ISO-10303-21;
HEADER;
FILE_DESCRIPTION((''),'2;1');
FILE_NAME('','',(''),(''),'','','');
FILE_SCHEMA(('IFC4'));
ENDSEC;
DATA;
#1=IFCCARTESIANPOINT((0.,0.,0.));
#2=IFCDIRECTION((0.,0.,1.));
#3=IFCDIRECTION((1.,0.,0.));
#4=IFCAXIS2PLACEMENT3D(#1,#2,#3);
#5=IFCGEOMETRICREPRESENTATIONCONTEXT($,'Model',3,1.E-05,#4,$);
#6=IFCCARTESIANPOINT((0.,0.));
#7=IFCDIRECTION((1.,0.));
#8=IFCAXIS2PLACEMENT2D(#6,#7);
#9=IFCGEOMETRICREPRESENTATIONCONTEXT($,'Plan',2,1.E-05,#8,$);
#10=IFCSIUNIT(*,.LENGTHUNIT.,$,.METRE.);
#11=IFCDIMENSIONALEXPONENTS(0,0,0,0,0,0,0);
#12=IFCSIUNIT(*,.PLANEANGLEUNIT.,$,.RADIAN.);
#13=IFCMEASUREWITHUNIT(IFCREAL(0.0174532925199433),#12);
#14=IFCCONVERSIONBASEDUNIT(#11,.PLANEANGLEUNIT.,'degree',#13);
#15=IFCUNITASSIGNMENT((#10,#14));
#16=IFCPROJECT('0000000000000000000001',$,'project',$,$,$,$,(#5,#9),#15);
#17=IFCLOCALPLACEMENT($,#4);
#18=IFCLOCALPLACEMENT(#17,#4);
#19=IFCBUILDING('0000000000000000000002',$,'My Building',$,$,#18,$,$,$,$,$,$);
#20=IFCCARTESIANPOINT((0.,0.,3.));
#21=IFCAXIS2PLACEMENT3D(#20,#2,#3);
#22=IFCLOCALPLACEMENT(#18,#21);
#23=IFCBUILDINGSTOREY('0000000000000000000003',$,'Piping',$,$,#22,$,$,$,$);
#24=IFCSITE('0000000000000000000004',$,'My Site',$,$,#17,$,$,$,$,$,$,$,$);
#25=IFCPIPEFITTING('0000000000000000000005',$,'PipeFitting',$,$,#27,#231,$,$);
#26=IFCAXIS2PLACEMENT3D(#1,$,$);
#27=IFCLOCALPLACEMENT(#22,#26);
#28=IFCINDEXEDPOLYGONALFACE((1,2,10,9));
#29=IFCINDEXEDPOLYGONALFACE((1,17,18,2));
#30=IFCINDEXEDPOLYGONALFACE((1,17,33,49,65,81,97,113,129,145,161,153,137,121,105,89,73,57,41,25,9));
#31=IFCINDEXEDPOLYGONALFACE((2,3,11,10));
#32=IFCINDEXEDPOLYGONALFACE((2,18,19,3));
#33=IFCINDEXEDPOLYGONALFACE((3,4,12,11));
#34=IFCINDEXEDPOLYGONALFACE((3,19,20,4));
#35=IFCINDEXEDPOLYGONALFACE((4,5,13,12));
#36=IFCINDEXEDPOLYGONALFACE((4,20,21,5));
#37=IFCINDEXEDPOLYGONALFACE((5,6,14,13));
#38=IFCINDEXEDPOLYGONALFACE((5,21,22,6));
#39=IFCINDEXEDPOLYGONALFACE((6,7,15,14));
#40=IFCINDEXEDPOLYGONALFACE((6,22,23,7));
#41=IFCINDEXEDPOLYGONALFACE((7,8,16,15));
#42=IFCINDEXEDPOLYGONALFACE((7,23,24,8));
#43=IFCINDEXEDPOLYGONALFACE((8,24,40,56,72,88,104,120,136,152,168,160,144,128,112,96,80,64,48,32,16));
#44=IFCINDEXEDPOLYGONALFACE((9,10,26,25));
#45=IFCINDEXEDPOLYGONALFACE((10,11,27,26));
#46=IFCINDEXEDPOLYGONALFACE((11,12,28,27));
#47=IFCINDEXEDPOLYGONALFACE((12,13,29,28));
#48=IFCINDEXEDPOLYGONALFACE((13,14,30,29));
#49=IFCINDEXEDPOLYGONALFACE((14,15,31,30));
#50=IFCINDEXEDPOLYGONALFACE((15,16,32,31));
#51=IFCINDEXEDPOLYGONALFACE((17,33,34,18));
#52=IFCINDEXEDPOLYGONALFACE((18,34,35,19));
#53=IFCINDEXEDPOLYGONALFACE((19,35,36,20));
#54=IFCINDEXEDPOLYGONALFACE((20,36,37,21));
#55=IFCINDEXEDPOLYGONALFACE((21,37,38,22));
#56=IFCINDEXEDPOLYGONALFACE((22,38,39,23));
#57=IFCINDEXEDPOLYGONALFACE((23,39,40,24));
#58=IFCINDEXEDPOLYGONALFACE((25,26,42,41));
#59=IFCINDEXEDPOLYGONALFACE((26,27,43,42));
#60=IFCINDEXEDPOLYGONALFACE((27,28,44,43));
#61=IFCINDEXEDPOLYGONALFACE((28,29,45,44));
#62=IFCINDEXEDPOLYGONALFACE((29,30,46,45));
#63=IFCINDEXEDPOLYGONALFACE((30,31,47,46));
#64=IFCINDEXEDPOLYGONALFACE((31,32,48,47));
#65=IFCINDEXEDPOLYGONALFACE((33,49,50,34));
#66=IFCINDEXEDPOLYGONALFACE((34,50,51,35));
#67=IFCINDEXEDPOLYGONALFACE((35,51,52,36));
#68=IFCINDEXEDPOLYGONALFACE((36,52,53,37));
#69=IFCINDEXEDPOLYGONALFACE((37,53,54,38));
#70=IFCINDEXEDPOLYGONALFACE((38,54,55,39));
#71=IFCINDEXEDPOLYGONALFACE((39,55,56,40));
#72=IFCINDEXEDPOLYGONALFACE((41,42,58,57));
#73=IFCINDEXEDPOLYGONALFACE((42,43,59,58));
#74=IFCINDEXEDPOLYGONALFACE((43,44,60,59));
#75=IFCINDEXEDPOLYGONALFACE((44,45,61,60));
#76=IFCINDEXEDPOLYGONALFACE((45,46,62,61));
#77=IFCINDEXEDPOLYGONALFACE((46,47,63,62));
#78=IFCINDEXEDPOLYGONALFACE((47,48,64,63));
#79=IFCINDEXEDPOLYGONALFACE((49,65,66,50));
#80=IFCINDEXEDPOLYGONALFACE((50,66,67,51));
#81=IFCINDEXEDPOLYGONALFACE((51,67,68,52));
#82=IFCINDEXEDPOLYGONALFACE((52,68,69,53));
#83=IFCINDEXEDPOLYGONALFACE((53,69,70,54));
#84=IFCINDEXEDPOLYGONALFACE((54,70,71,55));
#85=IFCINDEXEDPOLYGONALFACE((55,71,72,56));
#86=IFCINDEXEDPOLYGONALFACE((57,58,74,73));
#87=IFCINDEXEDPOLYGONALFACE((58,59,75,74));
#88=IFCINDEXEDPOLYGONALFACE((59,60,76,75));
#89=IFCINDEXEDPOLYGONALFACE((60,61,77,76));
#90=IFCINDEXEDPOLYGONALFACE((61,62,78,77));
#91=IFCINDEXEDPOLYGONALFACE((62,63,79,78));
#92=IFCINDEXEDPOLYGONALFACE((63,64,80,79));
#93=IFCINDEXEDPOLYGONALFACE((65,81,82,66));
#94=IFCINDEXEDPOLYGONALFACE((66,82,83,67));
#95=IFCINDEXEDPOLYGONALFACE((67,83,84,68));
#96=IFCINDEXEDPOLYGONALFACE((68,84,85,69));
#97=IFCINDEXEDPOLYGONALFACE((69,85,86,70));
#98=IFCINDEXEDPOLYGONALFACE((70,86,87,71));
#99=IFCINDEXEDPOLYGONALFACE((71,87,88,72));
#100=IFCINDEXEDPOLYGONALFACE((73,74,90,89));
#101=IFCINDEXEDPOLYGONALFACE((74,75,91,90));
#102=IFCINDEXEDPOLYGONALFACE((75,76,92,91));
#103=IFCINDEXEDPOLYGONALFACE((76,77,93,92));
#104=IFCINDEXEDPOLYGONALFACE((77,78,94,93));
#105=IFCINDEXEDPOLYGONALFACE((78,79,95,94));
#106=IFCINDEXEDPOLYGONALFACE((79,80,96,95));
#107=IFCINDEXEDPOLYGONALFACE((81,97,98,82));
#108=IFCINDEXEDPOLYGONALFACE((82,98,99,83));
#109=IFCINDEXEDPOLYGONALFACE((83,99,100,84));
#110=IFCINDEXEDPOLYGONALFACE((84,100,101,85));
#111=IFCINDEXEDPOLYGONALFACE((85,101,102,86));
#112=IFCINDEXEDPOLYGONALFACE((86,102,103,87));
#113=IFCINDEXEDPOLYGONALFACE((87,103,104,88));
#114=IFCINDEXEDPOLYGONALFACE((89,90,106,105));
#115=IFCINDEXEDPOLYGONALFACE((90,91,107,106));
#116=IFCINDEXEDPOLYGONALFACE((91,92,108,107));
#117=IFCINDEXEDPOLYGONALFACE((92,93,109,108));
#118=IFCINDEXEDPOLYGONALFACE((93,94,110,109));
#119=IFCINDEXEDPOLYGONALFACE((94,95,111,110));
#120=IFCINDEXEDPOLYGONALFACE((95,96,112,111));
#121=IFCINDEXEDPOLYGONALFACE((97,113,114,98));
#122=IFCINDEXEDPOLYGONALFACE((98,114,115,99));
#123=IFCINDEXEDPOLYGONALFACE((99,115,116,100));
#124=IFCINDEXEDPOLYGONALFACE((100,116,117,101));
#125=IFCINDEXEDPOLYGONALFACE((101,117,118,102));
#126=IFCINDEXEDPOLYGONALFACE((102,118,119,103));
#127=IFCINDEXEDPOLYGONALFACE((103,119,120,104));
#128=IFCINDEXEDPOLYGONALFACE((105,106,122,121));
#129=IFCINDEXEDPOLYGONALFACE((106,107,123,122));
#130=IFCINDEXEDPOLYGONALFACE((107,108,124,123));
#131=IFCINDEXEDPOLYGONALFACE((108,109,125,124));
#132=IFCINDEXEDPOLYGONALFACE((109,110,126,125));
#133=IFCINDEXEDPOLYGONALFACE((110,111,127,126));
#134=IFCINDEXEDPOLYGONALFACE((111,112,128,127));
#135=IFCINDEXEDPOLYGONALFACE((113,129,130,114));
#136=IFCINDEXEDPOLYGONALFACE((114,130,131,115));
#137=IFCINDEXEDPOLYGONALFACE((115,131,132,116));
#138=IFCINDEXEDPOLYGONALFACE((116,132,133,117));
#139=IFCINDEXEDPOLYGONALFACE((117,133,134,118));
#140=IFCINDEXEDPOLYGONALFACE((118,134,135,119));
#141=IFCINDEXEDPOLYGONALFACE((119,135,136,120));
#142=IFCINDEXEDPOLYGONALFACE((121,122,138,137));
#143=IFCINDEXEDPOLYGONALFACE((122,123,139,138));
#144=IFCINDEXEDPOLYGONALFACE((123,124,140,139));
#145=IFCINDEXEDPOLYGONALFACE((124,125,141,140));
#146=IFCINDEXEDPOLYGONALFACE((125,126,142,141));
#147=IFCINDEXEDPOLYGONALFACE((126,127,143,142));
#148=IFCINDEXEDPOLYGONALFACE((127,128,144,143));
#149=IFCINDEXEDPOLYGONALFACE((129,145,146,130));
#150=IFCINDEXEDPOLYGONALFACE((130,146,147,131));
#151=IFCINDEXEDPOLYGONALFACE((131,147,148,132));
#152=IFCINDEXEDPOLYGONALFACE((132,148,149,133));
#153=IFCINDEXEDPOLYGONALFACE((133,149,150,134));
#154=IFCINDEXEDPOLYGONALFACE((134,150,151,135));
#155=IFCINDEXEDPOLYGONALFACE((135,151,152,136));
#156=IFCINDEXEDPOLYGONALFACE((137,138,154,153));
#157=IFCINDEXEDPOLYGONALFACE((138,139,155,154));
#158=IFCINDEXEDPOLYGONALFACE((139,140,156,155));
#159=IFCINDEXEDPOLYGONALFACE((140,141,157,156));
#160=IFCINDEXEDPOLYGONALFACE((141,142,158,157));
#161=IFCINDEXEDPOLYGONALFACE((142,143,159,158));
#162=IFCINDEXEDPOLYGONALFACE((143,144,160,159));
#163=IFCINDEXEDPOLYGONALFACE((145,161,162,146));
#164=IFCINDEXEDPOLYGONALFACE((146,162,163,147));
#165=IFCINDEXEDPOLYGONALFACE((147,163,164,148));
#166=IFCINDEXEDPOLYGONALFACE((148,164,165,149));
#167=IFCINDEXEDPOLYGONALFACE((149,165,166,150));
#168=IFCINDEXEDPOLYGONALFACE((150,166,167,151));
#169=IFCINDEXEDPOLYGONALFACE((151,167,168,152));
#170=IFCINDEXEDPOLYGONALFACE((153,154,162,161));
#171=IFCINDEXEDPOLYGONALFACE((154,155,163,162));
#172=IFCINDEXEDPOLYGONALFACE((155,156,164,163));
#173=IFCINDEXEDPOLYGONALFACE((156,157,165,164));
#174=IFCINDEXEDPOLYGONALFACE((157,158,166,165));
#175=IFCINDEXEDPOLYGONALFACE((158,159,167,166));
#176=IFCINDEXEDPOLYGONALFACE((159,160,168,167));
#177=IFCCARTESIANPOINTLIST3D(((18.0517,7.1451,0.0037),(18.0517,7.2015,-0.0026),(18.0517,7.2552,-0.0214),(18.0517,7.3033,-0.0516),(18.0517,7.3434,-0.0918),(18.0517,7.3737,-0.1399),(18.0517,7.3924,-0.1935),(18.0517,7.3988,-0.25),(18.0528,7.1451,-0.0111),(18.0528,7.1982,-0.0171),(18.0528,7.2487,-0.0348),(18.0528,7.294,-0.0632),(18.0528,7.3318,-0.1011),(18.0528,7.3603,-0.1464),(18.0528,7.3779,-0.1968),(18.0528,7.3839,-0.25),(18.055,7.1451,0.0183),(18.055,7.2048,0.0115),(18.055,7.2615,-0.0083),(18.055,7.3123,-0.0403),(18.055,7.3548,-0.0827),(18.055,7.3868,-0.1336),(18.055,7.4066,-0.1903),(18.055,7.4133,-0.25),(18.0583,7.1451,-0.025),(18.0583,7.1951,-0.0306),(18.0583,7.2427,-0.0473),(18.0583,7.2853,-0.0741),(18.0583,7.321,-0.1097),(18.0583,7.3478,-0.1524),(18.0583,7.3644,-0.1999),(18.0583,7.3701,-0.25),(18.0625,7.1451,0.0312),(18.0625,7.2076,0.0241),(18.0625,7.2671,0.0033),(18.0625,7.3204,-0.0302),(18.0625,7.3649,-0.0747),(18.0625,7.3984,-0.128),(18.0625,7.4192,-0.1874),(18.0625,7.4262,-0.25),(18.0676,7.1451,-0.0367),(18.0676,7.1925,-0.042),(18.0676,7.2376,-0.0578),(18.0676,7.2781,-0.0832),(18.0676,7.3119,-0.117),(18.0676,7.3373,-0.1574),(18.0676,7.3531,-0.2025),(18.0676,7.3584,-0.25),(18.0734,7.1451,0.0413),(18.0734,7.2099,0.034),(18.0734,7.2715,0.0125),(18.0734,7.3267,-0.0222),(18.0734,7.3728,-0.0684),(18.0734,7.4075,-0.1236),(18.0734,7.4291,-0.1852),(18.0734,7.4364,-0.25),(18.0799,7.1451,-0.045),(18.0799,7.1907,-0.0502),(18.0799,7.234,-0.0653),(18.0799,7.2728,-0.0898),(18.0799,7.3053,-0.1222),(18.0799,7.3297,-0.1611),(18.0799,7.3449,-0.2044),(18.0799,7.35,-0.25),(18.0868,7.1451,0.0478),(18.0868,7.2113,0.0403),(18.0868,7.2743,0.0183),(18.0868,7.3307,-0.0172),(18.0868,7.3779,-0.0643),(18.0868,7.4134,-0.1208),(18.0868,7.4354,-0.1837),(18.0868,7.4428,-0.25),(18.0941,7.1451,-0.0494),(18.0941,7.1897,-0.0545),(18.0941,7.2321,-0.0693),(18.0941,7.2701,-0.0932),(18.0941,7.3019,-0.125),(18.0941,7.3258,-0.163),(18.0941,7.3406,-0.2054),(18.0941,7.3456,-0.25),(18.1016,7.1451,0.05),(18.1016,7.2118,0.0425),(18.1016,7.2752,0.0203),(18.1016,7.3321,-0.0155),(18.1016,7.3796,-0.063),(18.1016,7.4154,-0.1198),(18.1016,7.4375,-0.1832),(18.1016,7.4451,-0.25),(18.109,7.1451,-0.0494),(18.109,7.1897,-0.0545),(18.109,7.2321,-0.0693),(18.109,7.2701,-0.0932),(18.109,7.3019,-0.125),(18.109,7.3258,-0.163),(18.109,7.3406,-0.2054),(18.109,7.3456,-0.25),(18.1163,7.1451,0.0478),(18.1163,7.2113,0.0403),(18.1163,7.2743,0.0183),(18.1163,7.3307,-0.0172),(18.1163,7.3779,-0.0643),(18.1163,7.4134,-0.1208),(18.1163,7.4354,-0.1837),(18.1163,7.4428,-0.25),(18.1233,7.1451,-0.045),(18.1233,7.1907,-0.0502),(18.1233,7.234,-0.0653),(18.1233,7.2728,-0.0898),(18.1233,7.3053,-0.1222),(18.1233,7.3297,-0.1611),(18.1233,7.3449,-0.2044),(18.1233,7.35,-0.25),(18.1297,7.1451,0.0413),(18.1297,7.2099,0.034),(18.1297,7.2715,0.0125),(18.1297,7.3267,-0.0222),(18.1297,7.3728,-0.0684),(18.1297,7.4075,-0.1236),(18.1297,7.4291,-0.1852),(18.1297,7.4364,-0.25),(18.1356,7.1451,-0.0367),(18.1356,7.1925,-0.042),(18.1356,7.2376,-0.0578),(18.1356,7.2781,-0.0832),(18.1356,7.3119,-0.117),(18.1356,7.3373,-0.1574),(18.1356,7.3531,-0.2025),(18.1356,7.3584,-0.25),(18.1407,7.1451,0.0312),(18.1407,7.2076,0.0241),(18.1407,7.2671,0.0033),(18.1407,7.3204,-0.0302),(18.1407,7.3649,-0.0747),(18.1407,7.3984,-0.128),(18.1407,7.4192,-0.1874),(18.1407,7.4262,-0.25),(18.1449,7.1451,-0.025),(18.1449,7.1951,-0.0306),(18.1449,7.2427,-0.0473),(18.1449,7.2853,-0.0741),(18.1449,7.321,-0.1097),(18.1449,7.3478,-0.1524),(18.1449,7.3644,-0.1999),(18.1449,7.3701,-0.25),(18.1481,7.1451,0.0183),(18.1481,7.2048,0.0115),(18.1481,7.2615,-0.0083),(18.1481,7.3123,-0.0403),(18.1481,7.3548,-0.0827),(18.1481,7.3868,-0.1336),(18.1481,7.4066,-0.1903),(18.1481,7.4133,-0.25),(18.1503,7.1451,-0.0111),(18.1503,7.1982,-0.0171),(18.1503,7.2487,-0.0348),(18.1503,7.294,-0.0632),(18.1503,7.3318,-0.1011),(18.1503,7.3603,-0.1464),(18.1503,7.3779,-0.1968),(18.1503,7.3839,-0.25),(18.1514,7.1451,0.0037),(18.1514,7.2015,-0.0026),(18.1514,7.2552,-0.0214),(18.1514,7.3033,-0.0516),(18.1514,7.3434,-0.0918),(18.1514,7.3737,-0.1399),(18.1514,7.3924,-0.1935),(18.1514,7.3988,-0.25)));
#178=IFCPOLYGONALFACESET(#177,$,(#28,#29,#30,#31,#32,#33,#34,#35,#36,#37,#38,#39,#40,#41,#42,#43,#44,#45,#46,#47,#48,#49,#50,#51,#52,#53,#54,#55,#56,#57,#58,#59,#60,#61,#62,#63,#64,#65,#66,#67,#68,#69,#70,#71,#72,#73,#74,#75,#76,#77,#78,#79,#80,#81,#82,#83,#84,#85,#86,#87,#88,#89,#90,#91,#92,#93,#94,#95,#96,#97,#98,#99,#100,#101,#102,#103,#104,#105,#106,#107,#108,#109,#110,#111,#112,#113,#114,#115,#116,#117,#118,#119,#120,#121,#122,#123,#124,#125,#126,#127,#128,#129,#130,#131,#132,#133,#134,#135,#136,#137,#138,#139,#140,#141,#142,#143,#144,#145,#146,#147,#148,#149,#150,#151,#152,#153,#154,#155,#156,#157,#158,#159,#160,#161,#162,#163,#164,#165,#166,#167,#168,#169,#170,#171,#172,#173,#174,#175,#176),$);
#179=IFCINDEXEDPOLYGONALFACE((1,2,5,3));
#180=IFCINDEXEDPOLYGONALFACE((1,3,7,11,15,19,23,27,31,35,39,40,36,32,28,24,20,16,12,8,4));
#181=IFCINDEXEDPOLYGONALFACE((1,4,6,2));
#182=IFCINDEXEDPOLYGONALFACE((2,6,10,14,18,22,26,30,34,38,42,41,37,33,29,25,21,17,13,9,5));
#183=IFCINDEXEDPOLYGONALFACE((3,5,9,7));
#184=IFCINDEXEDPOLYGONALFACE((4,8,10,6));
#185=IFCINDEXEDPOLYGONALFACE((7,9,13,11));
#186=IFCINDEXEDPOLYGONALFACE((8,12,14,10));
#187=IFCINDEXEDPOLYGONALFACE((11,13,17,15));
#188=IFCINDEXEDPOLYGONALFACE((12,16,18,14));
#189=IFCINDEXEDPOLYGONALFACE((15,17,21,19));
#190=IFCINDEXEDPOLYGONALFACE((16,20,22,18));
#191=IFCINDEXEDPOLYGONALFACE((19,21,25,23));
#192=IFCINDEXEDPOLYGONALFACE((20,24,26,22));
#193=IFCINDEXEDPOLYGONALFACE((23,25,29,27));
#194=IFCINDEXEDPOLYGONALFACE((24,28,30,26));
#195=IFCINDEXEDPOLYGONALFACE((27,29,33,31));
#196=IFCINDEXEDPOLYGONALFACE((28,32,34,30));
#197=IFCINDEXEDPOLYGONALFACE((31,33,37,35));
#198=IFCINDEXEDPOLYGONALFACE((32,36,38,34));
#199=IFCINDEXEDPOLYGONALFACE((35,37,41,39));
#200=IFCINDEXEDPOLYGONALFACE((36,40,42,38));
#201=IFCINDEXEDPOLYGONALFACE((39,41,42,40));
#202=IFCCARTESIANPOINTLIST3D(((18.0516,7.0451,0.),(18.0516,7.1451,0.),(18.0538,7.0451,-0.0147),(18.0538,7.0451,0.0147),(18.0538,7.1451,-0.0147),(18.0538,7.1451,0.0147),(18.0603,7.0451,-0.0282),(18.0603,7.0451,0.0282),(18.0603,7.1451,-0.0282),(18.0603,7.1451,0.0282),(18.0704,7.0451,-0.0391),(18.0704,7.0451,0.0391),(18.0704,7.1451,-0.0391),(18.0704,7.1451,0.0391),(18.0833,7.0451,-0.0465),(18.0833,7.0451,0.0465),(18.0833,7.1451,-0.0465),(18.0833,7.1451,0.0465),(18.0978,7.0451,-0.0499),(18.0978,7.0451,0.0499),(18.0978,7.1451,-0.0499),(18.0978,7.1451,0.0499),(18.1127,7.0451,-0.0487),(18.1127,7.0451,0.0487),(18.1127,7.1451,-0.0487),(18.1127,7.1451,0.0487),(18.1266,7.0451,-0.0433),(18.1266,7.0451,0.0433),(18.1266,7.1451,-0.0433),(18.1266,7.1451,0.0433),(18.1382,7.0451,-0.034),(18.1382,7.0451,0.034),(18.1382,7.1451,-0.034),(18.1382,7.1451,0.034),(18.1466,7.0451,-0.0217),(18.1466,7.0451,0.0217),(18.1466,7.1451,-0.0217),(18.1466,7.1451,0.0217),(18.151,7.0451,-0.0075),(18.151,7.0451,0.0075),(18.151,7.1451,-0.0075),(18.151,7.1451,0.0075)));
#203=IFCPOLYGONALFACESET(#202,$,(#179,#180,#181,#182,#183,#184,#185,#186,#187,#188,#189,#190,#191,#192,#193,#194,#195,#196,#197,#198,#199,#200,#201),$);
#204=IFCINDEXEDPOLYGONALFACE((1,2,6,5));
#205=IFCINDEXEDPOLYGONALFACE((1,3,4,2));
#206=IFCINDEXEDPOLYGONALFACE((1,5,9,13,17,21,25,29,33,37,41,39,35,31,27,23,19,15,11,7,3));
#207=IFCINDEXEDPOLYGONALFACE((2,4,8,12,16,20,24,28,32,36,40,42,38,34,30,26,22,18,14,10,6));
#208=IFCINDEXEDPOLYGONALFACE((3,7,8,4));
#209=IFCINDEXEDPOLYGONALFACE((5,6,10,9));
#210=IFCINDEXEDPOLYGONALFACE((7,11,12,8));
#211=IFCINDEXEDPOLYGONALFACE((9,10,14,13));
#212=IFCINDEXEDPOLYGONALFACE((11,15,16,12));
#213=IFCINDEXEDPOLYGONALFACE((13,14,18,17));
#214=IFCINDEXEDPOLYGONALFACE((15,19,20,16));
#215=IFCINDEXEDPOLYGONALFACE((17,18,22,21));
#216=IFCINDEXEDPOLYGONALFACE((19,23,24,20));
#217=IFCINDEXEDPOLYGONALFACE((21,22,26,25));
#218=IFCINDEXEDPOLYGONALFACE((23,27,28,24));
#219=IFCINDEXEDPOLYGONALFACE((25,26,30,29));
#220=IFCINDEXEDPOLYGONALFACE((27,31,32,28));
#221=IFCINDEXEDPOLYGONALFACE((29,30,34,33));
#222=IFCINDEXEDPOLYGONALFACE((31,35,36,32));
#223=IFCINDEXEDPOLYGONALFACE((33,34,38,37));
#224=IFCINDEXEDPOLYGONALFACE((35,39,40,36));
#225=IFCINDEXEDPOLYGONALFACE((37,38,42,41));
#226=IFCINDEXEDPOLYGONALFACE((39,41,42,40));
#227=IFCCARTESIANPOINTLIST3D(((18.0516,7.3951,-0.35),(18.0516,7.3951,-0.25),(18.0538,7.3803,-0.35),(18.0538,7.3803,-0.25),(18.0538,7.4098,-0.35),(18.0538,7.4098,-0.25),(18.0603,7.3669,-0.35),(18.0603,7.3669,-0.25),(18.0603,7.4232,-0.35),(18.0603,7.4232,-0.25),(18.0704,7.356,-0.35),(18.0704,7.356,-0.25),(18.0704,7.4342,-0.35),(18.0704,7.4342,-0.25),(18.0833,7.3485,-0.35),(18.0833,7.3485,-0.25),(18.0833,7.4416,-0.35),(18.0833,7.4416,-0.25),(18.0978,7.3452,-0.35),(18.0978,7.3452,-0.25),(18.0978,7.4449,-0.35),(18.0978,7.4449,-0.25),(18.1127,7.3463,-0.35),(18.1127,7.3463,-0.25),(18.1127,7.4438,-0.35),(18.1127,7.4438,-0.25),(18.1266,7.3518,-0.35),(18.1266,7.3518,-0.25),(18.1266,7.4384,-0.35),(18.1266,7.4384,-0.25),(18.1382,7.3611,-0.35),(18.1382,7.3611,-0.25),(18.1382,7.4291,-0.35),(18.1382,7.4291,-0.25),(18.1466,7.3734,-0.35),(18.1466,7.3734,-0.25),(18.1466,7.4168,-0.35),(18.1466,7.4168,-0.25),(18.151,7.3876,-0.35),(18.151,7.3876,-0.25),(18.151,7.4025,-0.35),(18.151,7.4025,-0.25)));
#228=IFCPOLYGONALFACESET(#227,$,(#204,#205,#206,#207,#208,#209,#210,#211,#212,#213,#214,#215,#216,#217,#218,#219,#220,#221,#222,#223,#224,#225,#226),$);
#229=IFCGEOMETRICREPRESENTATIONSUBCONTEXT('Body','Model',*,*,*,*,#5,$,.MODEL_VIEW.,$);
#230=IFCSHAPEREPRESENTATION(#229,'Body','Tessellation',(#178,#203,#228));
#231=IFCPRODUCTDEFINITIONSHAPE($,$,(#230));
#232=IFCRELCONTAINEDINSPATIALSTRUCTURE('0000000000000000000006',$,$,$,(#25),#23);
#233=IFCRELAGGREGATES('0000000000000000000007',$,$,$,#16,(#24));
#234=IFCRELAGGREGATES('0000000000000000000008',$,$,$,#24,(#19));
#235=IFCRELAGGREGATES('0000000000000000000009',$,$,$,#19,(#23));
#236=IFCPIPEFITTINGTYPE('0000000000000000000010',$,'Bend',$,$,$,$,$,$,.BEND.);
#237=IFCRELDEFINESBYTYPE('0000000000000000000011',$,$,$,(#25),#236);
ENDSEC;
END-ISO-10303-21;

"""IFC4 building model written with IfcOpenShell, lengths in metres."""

from ifc_helpers import new_model, entity, si_unit, converted_unit, frame, origin_with_axes, origin_2d_with_axis, place, context, subcontext, project, spatial, circle, extrude, source, transform, mapped, type_object, type_shapes, element, save


model = new_model("IFC4")

# Units and contexts
model_context = context("Model", 3, precision=1e-05, world=origin_with_axes())
plan_context = context("Plan", 2, precision=1e-05, world=origin_2d_with_axis())
body_context = subcontext(model_context, "Body", "Model", "MODEL_VIEW")
ifc_project = project(units=[si_unit("LENGTHUNIT", "METRE"), converted_unit("PLANEANGLEUNIT", "degree", entity("IfcReal", 0.0174532925199433), si_unit("PLANEANGLEUNIT", "RADIAN"), dimensions=[0, 0, 0, 0, 0, 0, 0])], contexts=[model_context, plan_context])

# Site, building, storey
site_placement = place(None, origin_with_axes())
site = spatial("IfcSite", under=ifc_project, at=site_placement, Name="My Site")
building_placement = place(site_placement, origin_with_axes())
building = spatial("IfcBuilding", under=site, at=building_placement, Name="My Building")
storey_placement = place(building_placement, frame((0.0, 0.0, 3.0), z_axis=(0.0, 0.0, 1.0), x_axis=(1.0, 0.0, 0.0)))
storey = spatial("IfcBuildingStorey", under=building, at=storey_placement, Name="Piping")

# Shared definitions
pipe_fitting_type = type_object("IfcPipeFittingType", Name="Bend", PredefinedType="BEND")
shared_shape = source(origin_with_axes(), body_context, "Body", "SolidModel", [
    entity("IfcSweptDiskSolid", entity("IfcIndexedPolyCurve", entity("IfcCartesianPointList3D", [[0.0, 0.0, -0.1], [0.0, 0.0732, -0.2768], [0.0, 0.25, -0.35]]), [entity("IfcArcIndex", [1, 2, 3])]), 0.05),
    extrude(circle(Radius=0.05), origin_with_axes(), (0.0, 0.0, -1.0), 0.1),
    extrude(circle(Radius=0.05), frame((0.0, 0.25, -0.35), z_axis=(0.0, 1.0, 0.0), x_axis=(1.0, 0.0, 0.0)), (0.0, 0.0, 1.0), 0.1),
])
type_shapes(pipe_fitting_type, [shared_shape])

# Pipe fitting
for number, where, z_axis, x_axis, name in (
    (1, (18.1016, 7.0451, 0.0), (0.0, -1.0, 0.0), (-1.0, 0.0, 0.0), "PipeFitting"),
):
    element("IfcPipeFitting", number, at=place(storey_placement, frame(where, z_axis=z_axis, x_axis=x_axis)), inside=storey, type_object=pipe_fitting_type, Name=name, context=body_context, shape_type="MappedRepresentation", body=[
        mapped(shared_shape, transform((0.0, 0.0, 0.0), x_axis=(1.0, 0.0, 0.0), y_axis=(0.0, 1.0, 0.0), z_axis=(0.0, 0.0, 1.0), scale=1.0)),
    ])

save(model, "model.ifc")
